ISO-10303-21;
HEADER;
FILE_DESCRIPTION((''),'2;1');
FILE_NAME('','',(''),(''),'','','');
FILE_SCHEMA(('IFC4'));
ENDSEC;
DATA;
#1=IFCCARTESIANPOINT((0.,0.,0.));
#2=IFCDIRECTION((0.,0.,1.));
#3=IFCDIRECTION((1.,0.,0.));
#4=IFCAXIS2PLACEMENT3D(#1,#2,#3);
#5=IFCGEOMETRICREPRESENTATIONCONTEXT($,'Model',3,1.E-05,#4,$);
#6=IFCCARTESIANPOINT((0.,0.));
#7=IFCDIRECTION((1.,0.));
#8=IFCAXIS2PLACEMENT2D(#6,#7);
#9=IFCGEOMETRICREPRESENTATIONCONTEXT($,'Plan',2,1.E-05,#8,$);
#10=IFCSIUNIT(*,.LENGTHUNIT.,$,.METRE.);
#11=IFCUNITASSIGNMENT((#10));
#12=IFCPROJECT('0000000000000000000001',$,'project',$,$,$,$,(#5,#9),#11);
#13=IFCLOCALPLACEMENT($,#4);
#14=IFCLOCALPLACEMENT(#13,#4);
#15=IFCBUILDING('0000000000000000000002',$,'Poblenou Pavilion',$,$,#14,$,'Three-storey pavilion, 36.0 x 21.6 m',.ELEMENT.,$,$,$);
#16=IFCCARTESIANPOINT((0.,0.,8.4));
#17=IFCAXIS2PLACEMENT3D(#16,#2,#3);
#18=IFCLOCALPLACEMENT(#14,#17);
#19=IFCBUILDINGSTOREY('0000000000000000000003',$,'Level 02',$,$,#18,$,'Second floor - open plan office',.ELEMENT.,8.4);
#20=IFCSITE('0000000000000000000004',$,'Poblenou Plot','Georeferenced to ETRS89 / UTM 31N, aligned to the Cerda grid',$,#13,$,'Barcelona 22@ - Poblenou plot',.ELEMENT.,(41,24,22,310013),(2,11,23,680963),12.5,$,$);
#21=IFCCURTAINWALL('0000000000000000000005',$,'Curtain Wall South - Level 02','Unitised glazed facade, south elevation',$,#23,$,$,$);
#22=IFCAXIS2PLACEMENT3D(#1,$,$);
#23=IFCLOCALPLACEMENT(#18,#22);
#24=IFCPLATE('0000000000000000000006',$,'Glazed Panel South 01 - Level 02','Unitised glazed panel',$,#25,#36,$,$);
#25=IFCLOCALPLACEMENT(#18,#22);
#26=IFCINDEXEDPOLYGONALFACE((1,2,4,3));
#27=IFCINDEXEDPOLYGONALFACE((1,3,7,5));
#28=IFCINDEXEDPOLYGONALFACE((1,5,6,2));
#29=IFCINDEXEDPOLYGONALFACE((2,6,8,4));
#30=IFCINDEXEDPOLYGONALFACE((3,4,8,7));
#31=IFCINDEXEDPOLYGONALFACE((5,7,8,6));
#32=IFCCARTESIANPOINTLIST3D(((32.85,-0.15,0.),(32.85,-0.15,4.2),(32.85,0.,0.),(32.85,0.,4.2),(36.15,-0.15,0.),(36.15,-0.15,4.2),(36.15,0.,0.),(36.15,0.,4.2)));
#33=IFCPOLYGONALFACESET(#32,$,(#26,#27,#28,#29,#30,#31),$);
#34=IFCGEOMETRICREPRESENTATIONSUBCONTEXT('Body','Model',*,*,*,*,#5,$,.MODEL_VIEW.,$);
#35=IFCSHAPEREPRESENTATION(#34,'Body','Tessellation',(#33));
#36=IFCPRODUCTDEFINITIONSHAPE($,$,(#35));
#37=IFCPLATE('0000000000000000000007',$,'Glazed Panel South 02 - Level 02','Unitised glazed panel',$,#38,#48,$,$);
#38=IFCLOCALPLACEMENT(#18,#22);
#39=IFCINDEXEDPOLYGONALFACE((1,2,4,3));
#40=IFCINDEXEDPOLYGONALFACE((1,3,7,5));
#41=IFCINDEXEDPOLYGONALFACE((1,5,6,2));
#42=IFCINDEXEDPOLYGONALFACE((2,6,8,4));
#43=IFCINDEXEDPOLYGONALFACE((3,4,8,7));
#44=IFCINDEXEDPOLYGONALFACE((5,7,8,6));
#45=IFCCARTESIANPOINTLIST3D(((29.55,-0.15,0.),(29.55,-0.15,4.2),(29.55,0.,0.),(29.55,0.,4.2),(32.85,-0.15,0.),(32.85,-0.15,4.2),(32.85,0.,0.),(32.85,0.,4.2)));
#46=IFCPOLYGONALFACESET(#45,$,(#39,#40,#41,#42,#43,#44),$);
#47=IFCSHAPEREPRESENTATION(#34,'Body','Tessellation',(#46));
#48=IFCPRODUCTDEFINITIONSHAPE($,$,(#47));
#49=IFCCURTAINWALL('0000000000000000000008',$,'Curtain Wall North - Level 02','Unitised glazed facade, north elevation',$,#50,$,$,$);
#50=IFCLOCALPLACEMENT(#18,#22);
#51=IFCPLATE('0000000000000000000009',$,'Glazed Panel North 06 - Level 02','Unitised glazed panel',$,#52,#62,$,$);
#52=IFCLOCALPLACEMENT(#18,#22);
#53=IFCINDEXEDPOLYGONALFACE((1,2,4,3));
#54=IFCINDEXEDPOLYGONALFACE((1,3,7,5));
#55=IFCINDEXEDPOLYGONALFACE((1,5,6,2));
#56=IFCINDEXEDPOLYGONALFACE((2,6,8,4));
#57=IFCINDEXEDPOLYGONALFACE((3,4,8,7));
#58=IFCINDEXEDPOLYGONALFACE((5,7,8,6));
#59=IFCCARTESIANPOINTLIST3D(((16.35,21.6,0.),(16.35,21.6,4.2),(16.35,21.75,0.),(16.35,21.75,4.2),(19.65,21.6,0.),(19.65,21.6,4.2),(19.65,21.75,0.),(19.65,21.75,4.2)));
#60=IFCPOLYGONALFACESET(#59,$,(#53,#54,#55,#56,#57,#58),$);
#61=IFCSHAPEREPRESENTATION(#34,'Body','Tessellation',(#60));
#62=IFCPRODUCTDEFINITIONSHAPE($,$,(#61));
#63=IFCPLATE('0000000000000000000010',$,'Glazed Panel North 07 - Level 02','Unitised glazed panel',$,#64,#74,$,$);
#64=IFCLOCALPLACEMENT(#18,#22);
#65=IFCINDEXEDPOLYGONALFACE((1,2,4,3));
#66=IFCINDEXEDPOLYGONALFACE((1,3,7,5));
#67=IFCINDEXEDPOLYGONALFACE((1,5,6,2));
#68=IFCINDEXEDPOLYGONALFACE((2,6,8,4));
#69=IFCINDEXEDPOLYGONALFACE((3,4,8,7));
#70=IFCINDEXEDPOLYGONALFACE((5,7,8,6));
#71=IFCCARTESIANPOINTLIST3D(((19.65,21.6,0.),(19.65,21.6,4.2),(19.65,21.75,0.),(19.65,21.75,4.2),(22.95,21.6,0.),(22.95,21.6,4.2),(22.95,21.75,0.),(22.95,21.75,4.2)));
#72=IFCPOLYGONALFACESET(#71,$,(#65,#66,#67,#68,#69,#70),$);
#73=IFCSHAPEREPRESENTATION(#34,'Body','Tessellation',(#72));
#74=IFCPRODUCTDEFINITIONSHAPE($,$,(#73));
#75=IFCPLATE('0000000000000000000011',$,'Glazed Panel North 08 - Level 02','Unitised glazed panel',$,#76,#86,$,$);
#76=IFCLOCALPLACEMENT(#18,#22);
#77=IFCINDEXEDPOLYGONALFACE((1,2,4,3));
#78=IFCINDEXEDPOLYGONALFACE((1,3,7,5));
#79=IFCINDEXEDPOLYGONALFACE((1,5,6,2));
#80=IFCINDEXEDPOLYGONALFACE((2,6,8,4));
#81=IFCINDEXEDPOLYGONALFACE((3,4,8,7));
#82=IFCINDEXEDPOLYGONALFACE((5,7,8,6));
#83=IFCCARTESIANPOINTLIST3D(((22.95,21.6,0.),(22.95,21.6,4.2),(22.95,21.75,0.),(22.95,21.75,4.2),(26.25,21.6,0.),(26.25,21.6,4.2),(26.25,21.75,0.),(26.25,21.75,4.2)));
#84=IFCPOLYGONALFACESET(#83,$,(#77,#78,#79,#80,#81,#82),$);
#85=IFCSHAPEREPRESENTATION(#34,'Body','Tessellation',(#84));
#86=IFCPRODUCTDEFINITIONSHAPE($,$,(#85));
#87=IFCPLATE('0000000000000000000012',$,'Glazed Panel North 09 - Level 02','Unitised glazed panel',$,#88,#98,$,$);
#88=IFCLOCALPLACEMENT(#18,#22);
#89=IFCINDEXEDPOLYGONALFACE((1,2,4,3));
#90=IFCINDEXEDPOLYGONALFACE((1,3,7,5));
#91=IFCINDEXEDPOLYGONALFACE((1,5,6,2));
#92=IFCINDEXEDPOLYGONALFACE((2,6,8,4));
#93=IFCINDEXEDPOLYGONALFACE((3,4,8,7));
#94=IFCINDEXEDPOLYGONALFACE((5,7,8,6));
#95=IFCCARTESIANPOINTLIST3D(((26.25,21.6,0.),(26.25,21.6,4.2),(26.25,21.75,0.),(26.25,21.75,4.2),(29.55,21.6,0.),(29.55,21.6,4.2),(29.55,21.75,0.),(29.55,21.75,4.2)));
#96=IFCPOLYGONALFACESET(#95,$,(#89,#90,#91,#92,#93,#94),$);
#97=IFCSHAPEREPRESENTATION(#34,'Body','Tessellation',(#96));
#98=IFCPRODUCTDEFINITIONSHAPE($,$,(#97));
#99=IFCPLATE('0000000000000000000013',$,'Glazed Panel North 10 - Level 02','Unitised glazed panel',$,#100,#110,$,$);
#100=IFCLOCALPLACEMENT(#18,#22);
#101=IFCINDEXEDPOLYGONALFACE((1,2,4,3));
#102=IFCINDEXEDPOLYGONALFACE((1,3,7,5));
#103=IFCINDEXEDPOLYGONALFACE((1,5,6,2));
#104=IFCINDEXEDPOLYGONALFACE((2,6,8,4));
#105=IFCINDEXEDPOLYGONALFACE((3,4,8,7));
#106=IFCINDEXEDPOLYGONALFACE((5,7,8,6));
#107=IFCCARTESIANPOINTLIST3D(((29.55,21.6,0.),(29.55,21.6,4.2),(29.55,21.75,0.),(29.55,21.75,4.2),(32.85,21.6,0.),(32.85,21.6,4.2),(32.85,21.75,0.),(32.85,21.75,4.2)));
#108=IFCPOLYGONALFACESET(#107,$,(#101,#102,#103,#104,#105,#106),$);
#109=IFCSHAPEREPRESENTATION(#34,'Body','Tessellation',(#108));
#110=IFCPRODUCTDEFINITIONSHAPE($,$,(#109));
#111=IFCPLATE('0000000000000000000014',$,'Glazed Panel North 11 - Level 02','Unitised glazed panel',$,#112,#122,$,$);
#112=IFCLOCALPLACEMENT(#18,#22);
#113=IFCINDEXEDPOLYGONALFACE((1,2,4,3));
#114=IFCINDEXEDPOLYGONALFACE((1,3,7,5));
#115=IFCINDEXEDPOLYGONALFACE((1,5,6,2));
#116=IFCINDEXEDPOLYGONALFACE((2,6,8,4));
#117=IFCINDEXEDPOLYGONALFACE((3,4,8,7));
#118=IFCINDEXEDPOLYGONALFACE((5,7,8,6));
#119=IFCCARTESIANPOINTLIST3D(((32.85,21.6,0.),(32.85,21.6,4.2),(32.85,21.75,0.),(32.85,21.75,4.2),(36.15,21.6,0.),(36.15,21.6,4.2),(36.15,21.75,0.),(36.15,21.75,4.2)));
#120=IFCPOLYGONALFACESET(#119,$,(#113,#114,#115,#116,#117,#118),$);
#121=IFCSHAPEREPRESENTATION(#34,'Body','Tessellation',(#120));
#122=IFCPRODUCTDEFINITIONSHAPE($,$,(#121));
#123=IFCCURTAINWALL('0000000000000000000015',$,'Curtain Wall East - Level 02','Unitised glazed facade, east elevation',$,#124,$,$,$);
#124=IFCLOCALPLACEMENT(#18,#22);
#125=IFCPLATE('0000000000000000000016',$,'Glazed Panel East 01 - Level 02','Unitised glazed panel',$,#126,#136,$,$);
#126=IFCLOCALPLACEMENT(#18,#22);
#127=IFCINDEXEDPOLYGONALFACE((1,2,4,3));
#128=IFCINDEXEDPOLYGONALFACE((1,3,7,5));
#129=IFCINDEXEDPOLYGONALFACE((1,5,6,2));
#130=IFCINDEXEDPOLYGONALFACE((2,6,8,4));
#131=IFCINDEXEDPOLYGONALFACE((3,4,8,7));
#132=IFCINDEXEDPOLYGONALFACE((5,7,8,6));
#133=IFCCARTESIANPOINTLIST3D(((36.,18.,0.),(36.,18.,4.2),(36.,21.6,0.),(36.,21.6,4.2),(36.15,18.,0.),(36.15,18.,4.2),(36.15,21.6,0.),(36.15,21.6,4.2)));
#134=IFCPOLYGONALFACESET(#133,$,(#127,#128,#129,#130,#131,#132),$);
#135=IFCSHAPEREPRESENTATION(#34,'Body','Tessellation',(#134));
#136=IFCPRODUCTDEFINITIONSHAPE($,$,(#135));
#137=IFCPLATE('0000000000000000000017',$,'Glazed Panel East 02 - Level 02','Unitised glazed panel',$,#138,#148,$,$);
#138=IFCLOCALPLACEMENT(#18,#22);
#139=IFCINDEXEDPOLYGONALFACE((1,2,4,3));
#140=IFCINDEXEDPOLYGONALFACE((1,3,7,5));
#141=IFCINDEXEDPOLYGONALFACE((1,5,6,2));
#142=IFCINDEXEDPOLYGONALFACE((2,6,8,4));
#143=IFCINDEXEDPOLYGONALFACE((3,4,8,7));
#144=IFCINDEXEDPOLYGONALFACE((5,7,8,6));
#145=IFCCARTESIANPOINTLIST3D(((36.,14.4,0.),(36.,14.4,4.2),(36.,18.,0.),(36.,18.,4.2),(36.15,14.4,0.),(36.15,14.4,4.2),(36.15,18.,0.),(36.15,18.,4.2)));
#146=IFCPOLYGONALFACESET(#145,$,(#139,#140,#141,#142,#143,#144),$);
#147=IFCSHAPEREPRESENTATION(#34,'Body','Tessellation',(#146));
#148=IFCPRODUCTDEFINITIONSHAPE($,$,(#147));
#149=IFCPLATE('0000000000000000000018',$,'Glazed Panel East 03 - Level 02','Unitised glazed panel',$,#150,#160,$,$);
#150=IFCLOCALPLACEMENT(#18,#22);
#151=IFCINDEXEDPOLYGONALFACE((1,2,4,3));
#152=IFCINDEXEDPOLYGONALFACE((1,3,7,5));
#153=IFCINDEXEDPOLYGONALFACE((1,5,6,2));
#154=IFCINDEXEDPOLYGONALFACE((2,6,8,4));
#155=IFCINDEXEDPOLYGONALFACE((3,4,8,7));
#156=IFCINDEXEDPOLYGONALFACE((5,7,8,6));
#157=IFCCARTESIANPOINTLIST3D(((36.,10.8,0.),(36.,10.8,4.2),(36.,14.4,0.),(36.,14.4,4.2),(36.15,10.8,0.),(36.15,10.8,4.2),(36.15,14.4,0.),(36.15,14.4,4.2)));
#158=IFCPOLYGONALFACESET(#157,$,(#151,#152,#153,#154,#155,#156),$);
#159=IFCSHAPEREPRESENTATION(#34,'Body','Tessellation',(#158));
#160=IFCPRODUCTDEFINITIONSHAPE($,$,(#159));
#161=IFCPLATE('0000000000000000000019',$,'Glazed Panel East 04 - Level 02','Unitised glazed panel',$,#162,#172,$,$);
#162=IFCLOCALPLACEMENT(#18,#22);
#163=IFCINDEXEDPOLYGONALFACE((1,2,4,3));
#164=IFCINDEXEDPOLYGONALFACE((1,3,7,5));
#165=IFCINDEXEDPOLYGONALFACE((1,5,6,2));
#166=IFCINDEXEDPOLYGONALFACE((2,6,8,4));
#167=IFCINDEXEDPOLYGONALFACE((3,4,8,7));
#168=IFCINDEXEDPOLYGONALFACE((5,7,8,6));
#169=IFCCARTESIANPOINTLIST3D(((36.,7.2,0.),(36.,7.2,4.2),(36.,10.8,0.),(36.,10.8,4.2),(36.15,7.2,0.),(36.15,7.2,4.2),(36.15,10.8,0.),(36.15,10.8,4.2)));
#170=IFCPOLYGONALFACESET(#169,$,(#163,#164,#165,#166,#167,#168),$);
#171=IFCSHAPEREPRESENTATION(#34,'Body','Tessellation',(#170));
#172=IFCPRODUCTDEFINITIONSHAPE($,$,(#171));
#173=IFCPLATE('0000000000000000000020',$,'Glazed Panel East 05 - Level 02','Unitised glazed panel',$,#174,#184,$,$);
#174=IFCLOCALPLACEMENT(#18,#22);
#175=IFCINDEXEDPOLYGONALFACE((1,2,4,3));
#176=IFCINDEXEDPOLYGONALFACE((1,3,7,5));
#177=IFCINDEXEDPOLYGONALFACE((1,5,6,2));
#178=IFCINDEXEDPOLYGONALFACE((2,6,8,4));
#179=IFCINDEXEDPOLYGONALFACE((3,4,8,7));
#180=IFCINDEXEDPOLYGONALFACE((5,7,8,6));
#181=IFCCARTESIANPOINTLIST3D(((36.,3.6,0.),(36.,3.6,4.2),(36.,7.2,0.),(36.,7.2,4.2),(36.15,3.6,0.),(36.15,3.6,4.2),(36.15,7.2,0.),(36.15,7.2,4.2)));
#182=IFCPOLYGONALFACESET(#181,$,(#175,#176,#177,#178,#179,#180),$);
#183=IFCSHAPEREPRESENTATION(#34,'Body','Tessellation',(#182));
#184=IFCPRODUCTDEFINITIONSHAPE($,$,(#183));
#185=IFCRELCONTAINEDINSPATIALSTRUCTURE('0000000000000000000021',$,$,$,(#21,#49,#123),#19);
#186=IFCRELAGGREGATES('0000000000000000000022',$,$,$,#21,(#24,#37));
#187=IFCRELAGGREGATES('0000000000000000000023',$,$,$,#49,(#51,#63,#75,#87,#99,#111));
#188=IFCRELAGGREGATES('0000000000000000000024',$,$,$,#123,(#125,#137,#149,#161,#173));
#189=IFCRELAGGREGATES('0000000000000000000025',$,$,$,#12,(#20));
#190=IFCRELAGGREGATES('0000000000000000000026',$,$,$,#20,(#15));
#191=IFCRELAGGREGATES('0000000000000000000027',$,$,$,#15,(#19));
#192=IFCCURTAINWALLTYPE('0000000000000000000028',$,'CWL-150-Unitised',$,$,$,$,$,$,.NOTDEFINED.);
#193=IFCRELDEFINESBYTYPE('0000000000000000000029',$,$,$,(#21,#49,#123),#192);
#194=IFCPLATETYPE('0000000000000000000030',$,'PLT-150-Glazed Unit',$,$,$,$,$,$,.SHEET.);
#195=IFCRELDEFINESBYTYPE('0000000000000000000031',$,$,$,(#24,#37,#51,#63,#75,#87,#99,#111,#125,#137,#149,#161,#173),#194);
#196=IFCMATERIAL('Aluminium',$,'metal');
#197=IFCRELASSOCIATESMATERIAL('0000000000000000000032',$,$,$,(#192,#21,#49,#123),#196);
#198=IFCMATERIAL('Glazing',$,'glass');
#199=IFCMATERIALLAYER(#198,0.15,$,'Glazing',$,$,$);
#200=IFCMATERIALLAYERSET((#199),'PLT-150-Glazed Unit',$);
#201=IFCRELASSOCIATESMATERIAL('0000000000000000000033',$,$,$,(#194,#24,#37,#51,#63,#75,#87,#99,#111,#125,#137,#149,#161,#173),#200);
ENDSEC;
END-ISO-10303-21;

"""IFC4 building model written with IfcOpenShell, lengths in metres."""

from ifc_helpers import new_model, si_unit, frame, origin_with_axes, origin_2d_with_axis, place, context, subcontext, project, spatial, line, indexed_curve, outline, extrude, material, layer, layer_set, layer_usage, type_object, element, aggregate, save


model = new_model("IFC4")

# Units and contexts
model_context = context("Model", 3, precision=1e-05, world=origin_with_axes())
plan_context = context("Plan", 2, precision=1e-05, world=origin_2d_with_axis())
body_context = subcontext(model_context, "Body", "Model", "MODEL_VIEW")
ifc_project = project(units=[si_unit("LENGTHUNIT", "METRE")], contexts=[model_context, plan_context])

# Site, building, storey
site_placement = place(None, origin_with_axes())
site = spatial("IfcSite", under=ifc_project, at=site_placement, Name="Poblenou Plot", Description="Georeferenced to ETRS89 / UTM 31N, aligned to the Cerda grid", LongName="Barcelona 22@ - Poblenou plot", CompositionType="ELEMENT", RefLatitude=(41, 24, 22, 310013), RefLongitude=(2, 11, 23, 680963), RefElevation=12.5)
building_placement = place(site_placement, origin_with_axes())
building = spatial("IfcBuilding", under=site, at=building_placement, Name="Poblenou Pavilion", LongName="Three-storey pavilion, 36.0 x 21.6 m", CompositionType="ELEMENT")
storey_placement = place(building_placement, frame((0.0, 0.0, 8.4), z_axis=(0.0, 0.0, 1.0), x_axis=(1.0, 0.0, 0.0)))
storey = spatial("IfcBuildingStorey", under=building, at=storey_placement, Name="Level 02", LongName="Second floor - open plan office", CompositionType="ELEMENT", Elevation=8.4)

# Curtain walls, plates
ifc_material_1 = material(Name="Aluminium", Category="metal")
curtain_wall_type = type_object("IfcCurtainWallType", Name="CWL-150-Unitised", PredefinedType="NOTDEFINED", material=ifc_material_1)
curtain_wall_1_placement = place(storey_placement, frame((36.15, 0.0, 0.0), z_axis=(0.0, 0.0, 1.0), x_axis=(-1.0, 0.0, 0.0)))
curtain_wall_1 = element("IfcCurtainWall", 1, at=curtain_wall_1_placement, inside=storey, type_object=curtain_wall_type, material=ifc_material_1, Name="Curtain Wall South - Level 02", Description="Unitised glazed facade, south elevation")
ifc_material_2 = material(Name="Glazing", Category="glass")
ifc_layer_1 = layer(ifc_material_2, 0.15, Name="Glazing")
ifc_layer_set_1 = layer_set([ifc_layer_1], Name="PLT-150-Glazed Unit")
ifc_layer_usage_1 = layer_usage(ifc_layer_set_1, "AXIS2", "POSITIVE", 0.0)
plate_type = type_object("IfcPlateType", Name="PLT-150-Glazed Unit", PredefinedType="SHEET", material=ifc_layer_set_1)
plate_1_placement = place(curtain_wall_1_placement, origin_with_axes())
plate_1 = element("IfcPlate", 2, at=plate_1_placement, type_object=plate_type, material=ifc_layer_usage_1, Name="Glazed Panel South 01 - Level 02", Description="Unitised glazed panel", context=body_context, shape_type="SweptSolid", body=[
    extrude(outline(indexed_curve([(0.0, 0.0), (3.3, 0.0), (3.3, 0.15), (0.0, 0.15)], segments=[line(1, 2, 3, 4, 1)])), origin_with_axes(), (0.0, 0.0, 1.0), 4.2),
])
ifc_layer_usage_2 = layer_usage(ifc_layer_set_1, "AXIS2", "POSITIVE", 0.0)
plate_2_placement = place(curtain_wall_1_placement, frame((3.3, 0.0, 0.0), z_axis=(0.0, 0.0, 1.0), x_axis=(1.0, 0.0, 0.0)))
plate_2 = element("IfcPlate", 3, at=plate_2_placement, type_object=plate_type, material=ifc_layer_usage_2, Name="Glazed Panel South 02 - Level 02", Description="Unitised glazed panel", context=body_context, shape_type="SweptSolid", body=[
    extrude(outline(indexed_curve([(0.0, 0.0), (3.3, 0.0), (3.3, 0.15), (0.0, 0.15)], segments=[line(1, 2, 3, 4, 1)])), origin_with_axes(), (0.0, 0.0, 1.0), 4.2),
])
aggregate(curtain_wall_1, [plate_1, plate_2])
curtain_wall_2_placement = place(storey_placement, frame((-0.15, 21.6, 0.0), z_axis=(0.0, 0.0, 1.0), x_axis=(1.0, 0.0, 0.0)))
curtain_wall_2 = element("IfcCurtainWall", 4, at=curtain_wall_2_placement, inside=storey, type_object=curtain_wall_type, material=ifc_material_1, Name="Curtain Wall North - Level 02", Description="Unitised glazed facade, north elevation")
ifc_layer_usage_3 = layer_usage(ifc_layer_set_1, "AXIS2", "POSITIVE", 0.0)
plate_3_placement = place(curtain_wall_2_placement, frame((16.5, 0.0, 0.0), z_axis=(0.0, 0.0, 1.0), x_axis=(1.0, 0.0, 0.0)))
plate_3 = element("IfcPlate", 5, at=plate_3_placement, type_object=plate_type, material=ifc_layer_usage_3, Name="Glazed Panel North 06 - Level 02", Description="Unitised glazed panel", context=body_context, shape_type="SweptSolid", body=[
    extrude(outline(indexed_curve([(0.0, 0.0), (3.3, 0.0), (3.3, 0.15), (0.0, 0.15)], segments=[line(1, 2, 3, 4, 1)])), origin_with_axes(), (0.0, 0.0, 1.0), 4.2),
])
ifc_layer_usage_4 = layer_usage(ifc_layer_set_1, "AXIS2", "POSITIVE", 0.0)
plate_4_placement = place(curtain_wall_2_placement, frame((19.8, 0.0, 0.0), z_axis=(0.0, 0.0, 1.0), x_axis=(1.0, 0.0, 0.0)))
plate_4 = element("IfcPlate", 6, at=plate_4_placement, type_object=plate_type, material=ifc_layer_usage_4, Name="Glazed Panel North 07 - Level 02", Description="Unitised glazed panel", context=body_context, shape_type="SweptSolid", body=[
    extrude(outline(indexed_curve([(0.0, 0.0), (3.3, 0.0), (3.3, 0.15), (0.0, 0.15)], segments=[line(1, 2, 3, 4, 1)])), origin_with_axes(), (0.0, 0.0, 1.0), 4.2),
])
ifc_layer_usage_5 = layer_usage(ifc_layer_set_1, "AXIS2", "POSITIVE", 0.0)
plate_5_placement = place(curtain_wall_2_placement, frame((23.1, 0.0, 0.0), z_axis=(0.0, 0.0, 1.0), x_axis=(1.0, 0.0, 0.0)))
plate_5 = element("IfcPlate", 7, at=plate_5_placement, type_object=plate_type, material=ifc_layer_usage_5, Name="Glazed Panel North 08 - Level 02", Description="Unitised glazed panel", context=body_context, shape_type="SweptSolid", body=[
    extrude(outline(indexed_curve([(0.0, 0.0), (3.3, 0.0), (3.3, 0.15), (0.0, 0.15)], segments=[line(1, 2, 3, 4, 1)])), origin_with_axes(), (0.0, 0.0, 1.0), 4.2),
])
ifc_layer_usage_6 = layer_usage(ifc_layer_set_1, "AXIS2", "POSITIVE", 0.0)
plate_6_placement = place(curtain_wall_2_placement, frame((26.4, 0.0, 0.0), z_axis=(0.0, 0.0, 1.0), x_axis=(1.0, 0.0, 0.0)))
plate_6 = element("IfcPlate", 8, at=plate_6_placement, type_object=plate_type, material=ifc_layer_usage_6, Name="Glazed Panel North 09 - Level 02", Description="Unitised glazed panel", context=body_context, shape_type="SweptSolid", body=[
    extrude(outline(indexed_curve([(0.0, 0.0), (3.3, 0.0), (3.3, 0.15), (0.0, 0.15)], segments=[line(1, 2, 3, 4, 1)])), origin_with_axes(), (0.0, 0.0, 1.0), 4.2),
])
ifc_layer_usage_7 = layer_usage(ifc_layer_set_1, "AXIS2", "POSITIVE", 0.0)
plate_7_placement = place(curtain_wall_2_placement, frame((29.7, 0.0, 0.0), z_axis=(0.0, 0.0, 1.0), x_axis=(1.0, 0.0, 0.0)))
plate_7 = element("IfcPlate", 9, at=plate_7_placement, type_object=plate_type, material=ifc_layer_usage_7, Name="Glazed Panel North 10 - Level 02", Description="Unitised glazed panel", context=body_context, shape_type="SweptSolid", body=[
    extrude(outline(indexed_curve([(0.0, 0.0), (3.3, 0.0), (3.3, 0.15), (0.0, 0.15)], segments=[line(1, 2, 3, 4, 1)])), origin_with_axes(), (0.0, 0.0, 1.0), 4.2),
])
ifc_layer_usage_8 = layer_usage(ifc_layer_set_1, "AXIS2", "POSITIVE", 0.0)
plate_8_placement = place(curtain_wall_2_placement, frame((33.0, 0.0, 0.0), z_axis=(0.0, 0.0, 1.0), x_axis=(1.0, 0.0, 0.0)))
plate_8 = element("IfcPlate", 10, at=plate_8_placement, type_object=plate_type, material=ifc_layer_usage_8, Name="Glazed Panel North 11 - Level 02", Description="Unitised glazed panel", context=body_context, shape_type="SweptSolid", body=[
    extrude(outline(indexed_curve([(0.0, 0.0), (3.3, 0.0), (3.3, 0.15), (0.0, 0.15)], segments=[line(1, 2, 3, 4, 1)])), origin_with_axes(), (0.0, 0.0, 1.0), 4.2),
])
aggregate(curtain_wall_2, [plate_3, plate_4, plate_5, plate_6, plate_7, plate_8])
curtain_wall_3_placement = place(storey_placement, frame((36.0, 21.6, 0.0), z_axis=(0.0, 0.0, 1.0), x_axis=(0.0, -1.0, 0.0)))
curtain_wall_3 = element("IfcCurtainWall", 11, at=curtain_wall_3_placement, inside=storey, type_object=curtain_wall_type, material=ifc_material_1, Name="Curtain Wall East - Level 02", Description="Unitised glazed facade, east elevation")
ifc_layer_usage_9 = layer_usage(ifc_layer_set_1, "AXIS2", "POSITIVE", 0.0)
plate_9_placement = place(curtain_wall_3_placement, origin_with_axes())
plate_9 = element("IfcPlate", 12, at=plate_9_placement, type_object=plate_type, material=ifc_layer_usage_9, Name="Glazed Panel East 01 - Level 02", Description="Unitised glazed panel", context=body_context, shape_type="SweptSolid", body=[
    extrude(outline(indexed_curve([(0.0, 0.0), (3.6, 0.0), (3.6, 0.15), (0.0, 0.15)], segments=[line(1, 2, 3, 4, 1)])), origin_with_axes(), (0.0, 0.0, 1.0), 4.2),
])
ifc_layer_usage_10 = layer_usage(ifc_layer_set_1, "AXIS2", "POSITIVE", 0.0)
plate_10_placement = place(curtain_wall_3_placement, frame((3.6, 0.0, 0.0), z_axis=(0.0, 0.0, 1.0), x_axis=(1.0, 0.0, 0.0)))
plate_10 = element("IfcPlate", 13, at=plate_10_placement, type_object=plate_type, material=ifc_layer_usage_10, Name="Glazed Panel East 02 - Level 02", Description="Unitised glazed panel", context=body_context, shape_type="SweptSolid", body=[
    extrude(outline(indexed_curve([(0.0, 0.0), (3.6, 0.0), (3.6, 0.15), (0.0, 0.15)], segments=[line(1, 2, 3, 4, 1)])), origin_with_axes(), (0.0, 0.0, 1.0), 4.2),
])
ifc_layer_usage_11 = layer_usage(ifc_layer_set_1, "AXIS2", "POSITIVE", 0.0)
plate_11_placement = place(curtain_wall_3_placement, frame((7.2, 0.0, 0.0), z_axis=(0.0, 0.0, 1.0), x_axis=(1.0, 0.0, 0.0)))
plate_11 = element("IfcPlate", 14, at=plate_11_placement, type_object=plate_type, material=ifc_layer_usage_11, Name="Glazed Panel East 03 - Level 02", Description="Unitised glazed panel", context=body_context, shape_type="SweptSolid", body=[
    extrude(outline(indexed_curve([(0.0, 0.0), (3.6, 0.0), (3.6, 0.15), (0.0, 0.15)], segments=[line(1, 2, 3, 4, 1)])), origin_with_axes(), (0.0, 0.0, 1.0), 4.2),
])
ifc_layer_usage_12 = layer_usage(ifc_layer_set_1, "AXIS2", "POSITIVE", 0.0)
plate_12_placement = place(curtain_wall_3_placement, frame((10.8, 0.0, 0.0), z_axis=(0.0, 0.0, 1.0), x_axis=(1.0, 0.0, 0.0)))
plate_12 = element("IfcPlate", 15, at=plate_12_placement, type_object=plate_type, material=ifc_layer_usage_12, Name="Glazed Panel East 04 - Level 02", Description="Unitised glazed panel", context=body_context, shape_type="SweptSolid", body=[
    extrude(outline(indexed_curve([(0.0, 0.0), (3.6, 0.0), (3.6, 0.15), (0.0, 0.15)], segments=[line(1, 2, 3, 4, 1)])), origin_with_axes(), (0.0, 0.0, 1.0), 4.2),
])
ifc_layer_usage_13 = layer_usage(ifc_layer_set_1, "AXIS2", "POSITIVE", 0.0)
plate_13_placement = place(curtain_wall_3_placement, frame((14.4, 0.0, 0.0), z_axis=(0.0, 0.0, 1.0), x_axis=(1.0, 0.0, 0.0)))
plate_13 = element("IfcPlate", 16, at=plate_13_placement, type_object=plate_type, material=ifc_layer_usage_13, Name="Glazed Panel East 05 - Level 02", Description="Unitised glazed panel", context=body_context, shape_type="SweptSolid", body=[
    extrude(outline(indexed_curve([(0.0, 0.0), (3.6, 0.0), (3.6, 0.15), (0.0, 0.15)], segments=[line(1, 2, 3, 4, 1)])), origin_with_axes(), (0.0, 0.0, 1.0), 4.2),
])
aggregate(curtain_wall_3, [plate_9, plate_10, plate_11, plate_12, plate_13])

save(model, "model.ifc")
